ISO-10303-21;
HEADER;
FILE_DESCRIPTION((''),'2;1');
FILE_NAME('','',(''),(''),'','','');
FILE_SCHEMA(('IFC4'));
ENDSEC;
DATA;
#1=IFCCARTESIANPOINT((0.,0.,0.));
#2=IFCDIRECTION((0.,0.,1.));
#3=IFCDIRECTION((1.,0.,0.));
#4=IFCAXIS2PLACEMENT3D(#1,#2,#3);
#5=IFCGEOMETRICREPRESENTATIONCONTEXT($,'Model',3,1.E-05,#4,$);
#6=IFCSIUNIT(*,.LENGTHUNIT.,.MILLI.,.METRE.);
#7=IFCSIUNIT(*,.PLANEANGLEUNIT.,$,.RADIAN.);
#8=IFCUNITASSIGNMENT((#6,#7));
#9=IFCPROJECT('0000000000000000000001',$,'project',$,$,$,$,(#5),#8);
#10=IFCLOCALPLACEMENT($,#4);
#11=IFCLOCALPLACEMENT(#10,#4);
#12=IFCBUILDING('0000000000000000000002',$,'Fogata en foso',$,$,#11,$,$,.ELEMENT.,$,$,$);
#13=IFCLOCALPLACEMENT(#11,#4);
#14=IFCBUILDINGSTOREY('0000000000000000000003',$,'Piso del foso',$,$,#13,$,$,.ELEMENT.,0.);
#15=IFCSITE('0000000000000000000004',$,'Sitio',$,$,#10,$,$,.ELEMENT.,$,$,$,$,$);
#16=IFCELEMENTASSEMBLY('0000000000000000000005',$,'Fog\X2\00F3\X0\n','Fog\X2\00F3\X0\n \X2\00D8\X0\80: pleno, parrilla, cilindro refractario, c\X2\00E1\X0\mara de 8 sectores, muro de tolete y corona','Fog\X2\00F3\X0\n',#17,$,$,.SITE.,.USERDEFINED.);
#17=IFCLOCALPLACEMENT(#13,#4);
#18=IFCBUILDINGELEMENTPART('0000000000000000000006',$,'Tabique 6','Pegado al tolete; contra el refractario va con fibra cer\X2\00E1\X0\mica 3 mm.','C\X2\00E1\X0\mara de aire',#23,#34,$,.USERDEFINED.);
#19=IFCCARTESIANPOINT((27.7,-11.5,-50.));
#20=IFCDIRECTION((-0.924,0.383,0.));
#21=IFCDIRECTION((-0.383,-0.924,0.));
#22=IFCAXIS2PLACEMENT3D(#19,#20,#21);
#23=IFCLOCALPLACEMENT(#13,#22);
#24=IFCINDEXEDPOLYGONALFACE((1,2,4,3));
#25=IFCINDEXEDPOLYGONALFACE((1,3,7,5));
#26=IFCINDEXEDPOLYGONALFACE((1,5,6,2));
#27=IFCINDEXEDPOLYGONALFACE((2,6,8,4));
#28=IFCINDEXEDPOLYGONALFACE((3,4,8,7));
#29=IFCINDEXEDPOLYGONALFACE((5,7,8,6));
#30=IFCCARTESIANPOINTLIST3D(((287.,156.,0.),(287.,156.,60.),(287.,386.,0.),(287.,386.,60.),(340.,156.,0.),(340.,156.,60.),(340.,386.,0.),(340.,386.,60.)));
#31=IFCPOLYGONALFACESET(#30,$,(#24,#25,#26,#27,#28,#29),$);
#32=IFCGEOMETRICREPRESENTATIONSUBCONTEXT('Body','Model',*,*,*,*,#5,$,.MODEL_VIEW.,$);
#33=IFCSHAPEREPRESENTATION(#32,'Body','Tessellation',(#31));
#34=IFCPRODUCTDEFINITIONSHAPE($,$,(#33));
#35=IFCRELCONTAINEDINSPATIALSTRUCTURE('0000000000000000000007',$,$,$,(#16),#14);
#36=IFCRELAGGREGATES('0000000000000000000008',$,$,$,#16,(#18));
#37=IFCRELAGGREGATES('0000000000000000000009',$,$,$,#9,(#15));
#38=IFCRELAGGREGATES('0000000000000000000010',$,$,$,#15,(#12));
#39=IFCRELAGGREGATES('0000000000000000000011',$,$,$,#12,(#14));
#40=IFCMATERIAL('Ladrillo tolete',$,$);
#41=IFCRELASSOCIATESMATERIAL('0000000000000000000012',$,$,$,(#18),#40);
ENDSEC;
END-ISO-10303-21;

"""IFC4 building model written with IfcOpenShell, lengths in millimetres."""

from ifc_helpers import new_model, si_unit, frame, origin_with_axes, place, context, subcontext, project, spatial, polyline, outline, extrude, material, element, aggregate, save


model = new_model("IFC4")

# Units and contexts
model_context = context("Model", 3, precision=1e-05, world=origin_with_axes())
body_context = subcontext(model_context, "Body", "Model", "MODEL_VIEW")
ifc_project = project(units=[si_unit("LENGTHUNIT", "METRE", prefix="MILLI"), si_unit("PLANEANGLEUNIT", "RADIAN")], contexts=[model_context])

# Site, building, storey
site_placement = place(None, origin_with_axes())
site = spatial("IfcSite", under=ifc_project, at=site_placement, Name="Sitio", CompositionType="ELEMENT")
building_placement = place(site_placement, origin_with_axes())
building = spatial("IfcBuilding", under=site, at=building_placement, Name="Fogata en foso", CompositionType="ELEMENT")
storey_placement = place(building_placement, origin_with_axes())
storey = spatial("IfcBuildingStorey", under=building, at=storey_placement, Name="Piso del foso", CompositionType="ELEMENT", Elevation=0.0)

# Element assembly, building element part
assembly_1_placement = place(storey_placement, origin_with_axes())
assembly_1 = element("IfcElementAssembly", 1, at=assembly_1_placement, inside=storey, Name="Fogón", Description="Fogón Ø80: pleno, parrilla, cilindro refractario, cámara de 8 sectores, muro de tolete y corona", ObjectType="Fogón", AssemblyPlace="SITE", PredefinedType="USERDEFINED")
ifc_material_1 = material(Name="Ladrillo tolete")
building_element_part_1_placement = place(storey_placement, frame((27.7, -11.5, -50.0), z_axis=(-0.924, 0.383, 0.0), x_axis=(-0.383, -0.924, 0.0)))
building_element_part_1 = element("IfcBuildingElementPart", 2, at=building_element_part_1_placement, material=ifc_material_1, Name="Tabique 6", Description="Pegado al tolete; contra el refractario va con fibra cerámica 3 mm.", ObjectType="Cámara de aire", PredefinedType="USERDEFINED", context=body_context, shape_type="SweptSolid", body=[
    extrude(outline(polyline([(287.0, 156.0), (340.0, 156.0), (340.0, 386.0), (287.0, 386.0), (287.0, 156.0)])), origin_with_axes(), (0.0, 0.0, 1.0), 60.0),
])
aggregate(assembly_1, [building_element_part_1])

save(model, "model.ifc")
